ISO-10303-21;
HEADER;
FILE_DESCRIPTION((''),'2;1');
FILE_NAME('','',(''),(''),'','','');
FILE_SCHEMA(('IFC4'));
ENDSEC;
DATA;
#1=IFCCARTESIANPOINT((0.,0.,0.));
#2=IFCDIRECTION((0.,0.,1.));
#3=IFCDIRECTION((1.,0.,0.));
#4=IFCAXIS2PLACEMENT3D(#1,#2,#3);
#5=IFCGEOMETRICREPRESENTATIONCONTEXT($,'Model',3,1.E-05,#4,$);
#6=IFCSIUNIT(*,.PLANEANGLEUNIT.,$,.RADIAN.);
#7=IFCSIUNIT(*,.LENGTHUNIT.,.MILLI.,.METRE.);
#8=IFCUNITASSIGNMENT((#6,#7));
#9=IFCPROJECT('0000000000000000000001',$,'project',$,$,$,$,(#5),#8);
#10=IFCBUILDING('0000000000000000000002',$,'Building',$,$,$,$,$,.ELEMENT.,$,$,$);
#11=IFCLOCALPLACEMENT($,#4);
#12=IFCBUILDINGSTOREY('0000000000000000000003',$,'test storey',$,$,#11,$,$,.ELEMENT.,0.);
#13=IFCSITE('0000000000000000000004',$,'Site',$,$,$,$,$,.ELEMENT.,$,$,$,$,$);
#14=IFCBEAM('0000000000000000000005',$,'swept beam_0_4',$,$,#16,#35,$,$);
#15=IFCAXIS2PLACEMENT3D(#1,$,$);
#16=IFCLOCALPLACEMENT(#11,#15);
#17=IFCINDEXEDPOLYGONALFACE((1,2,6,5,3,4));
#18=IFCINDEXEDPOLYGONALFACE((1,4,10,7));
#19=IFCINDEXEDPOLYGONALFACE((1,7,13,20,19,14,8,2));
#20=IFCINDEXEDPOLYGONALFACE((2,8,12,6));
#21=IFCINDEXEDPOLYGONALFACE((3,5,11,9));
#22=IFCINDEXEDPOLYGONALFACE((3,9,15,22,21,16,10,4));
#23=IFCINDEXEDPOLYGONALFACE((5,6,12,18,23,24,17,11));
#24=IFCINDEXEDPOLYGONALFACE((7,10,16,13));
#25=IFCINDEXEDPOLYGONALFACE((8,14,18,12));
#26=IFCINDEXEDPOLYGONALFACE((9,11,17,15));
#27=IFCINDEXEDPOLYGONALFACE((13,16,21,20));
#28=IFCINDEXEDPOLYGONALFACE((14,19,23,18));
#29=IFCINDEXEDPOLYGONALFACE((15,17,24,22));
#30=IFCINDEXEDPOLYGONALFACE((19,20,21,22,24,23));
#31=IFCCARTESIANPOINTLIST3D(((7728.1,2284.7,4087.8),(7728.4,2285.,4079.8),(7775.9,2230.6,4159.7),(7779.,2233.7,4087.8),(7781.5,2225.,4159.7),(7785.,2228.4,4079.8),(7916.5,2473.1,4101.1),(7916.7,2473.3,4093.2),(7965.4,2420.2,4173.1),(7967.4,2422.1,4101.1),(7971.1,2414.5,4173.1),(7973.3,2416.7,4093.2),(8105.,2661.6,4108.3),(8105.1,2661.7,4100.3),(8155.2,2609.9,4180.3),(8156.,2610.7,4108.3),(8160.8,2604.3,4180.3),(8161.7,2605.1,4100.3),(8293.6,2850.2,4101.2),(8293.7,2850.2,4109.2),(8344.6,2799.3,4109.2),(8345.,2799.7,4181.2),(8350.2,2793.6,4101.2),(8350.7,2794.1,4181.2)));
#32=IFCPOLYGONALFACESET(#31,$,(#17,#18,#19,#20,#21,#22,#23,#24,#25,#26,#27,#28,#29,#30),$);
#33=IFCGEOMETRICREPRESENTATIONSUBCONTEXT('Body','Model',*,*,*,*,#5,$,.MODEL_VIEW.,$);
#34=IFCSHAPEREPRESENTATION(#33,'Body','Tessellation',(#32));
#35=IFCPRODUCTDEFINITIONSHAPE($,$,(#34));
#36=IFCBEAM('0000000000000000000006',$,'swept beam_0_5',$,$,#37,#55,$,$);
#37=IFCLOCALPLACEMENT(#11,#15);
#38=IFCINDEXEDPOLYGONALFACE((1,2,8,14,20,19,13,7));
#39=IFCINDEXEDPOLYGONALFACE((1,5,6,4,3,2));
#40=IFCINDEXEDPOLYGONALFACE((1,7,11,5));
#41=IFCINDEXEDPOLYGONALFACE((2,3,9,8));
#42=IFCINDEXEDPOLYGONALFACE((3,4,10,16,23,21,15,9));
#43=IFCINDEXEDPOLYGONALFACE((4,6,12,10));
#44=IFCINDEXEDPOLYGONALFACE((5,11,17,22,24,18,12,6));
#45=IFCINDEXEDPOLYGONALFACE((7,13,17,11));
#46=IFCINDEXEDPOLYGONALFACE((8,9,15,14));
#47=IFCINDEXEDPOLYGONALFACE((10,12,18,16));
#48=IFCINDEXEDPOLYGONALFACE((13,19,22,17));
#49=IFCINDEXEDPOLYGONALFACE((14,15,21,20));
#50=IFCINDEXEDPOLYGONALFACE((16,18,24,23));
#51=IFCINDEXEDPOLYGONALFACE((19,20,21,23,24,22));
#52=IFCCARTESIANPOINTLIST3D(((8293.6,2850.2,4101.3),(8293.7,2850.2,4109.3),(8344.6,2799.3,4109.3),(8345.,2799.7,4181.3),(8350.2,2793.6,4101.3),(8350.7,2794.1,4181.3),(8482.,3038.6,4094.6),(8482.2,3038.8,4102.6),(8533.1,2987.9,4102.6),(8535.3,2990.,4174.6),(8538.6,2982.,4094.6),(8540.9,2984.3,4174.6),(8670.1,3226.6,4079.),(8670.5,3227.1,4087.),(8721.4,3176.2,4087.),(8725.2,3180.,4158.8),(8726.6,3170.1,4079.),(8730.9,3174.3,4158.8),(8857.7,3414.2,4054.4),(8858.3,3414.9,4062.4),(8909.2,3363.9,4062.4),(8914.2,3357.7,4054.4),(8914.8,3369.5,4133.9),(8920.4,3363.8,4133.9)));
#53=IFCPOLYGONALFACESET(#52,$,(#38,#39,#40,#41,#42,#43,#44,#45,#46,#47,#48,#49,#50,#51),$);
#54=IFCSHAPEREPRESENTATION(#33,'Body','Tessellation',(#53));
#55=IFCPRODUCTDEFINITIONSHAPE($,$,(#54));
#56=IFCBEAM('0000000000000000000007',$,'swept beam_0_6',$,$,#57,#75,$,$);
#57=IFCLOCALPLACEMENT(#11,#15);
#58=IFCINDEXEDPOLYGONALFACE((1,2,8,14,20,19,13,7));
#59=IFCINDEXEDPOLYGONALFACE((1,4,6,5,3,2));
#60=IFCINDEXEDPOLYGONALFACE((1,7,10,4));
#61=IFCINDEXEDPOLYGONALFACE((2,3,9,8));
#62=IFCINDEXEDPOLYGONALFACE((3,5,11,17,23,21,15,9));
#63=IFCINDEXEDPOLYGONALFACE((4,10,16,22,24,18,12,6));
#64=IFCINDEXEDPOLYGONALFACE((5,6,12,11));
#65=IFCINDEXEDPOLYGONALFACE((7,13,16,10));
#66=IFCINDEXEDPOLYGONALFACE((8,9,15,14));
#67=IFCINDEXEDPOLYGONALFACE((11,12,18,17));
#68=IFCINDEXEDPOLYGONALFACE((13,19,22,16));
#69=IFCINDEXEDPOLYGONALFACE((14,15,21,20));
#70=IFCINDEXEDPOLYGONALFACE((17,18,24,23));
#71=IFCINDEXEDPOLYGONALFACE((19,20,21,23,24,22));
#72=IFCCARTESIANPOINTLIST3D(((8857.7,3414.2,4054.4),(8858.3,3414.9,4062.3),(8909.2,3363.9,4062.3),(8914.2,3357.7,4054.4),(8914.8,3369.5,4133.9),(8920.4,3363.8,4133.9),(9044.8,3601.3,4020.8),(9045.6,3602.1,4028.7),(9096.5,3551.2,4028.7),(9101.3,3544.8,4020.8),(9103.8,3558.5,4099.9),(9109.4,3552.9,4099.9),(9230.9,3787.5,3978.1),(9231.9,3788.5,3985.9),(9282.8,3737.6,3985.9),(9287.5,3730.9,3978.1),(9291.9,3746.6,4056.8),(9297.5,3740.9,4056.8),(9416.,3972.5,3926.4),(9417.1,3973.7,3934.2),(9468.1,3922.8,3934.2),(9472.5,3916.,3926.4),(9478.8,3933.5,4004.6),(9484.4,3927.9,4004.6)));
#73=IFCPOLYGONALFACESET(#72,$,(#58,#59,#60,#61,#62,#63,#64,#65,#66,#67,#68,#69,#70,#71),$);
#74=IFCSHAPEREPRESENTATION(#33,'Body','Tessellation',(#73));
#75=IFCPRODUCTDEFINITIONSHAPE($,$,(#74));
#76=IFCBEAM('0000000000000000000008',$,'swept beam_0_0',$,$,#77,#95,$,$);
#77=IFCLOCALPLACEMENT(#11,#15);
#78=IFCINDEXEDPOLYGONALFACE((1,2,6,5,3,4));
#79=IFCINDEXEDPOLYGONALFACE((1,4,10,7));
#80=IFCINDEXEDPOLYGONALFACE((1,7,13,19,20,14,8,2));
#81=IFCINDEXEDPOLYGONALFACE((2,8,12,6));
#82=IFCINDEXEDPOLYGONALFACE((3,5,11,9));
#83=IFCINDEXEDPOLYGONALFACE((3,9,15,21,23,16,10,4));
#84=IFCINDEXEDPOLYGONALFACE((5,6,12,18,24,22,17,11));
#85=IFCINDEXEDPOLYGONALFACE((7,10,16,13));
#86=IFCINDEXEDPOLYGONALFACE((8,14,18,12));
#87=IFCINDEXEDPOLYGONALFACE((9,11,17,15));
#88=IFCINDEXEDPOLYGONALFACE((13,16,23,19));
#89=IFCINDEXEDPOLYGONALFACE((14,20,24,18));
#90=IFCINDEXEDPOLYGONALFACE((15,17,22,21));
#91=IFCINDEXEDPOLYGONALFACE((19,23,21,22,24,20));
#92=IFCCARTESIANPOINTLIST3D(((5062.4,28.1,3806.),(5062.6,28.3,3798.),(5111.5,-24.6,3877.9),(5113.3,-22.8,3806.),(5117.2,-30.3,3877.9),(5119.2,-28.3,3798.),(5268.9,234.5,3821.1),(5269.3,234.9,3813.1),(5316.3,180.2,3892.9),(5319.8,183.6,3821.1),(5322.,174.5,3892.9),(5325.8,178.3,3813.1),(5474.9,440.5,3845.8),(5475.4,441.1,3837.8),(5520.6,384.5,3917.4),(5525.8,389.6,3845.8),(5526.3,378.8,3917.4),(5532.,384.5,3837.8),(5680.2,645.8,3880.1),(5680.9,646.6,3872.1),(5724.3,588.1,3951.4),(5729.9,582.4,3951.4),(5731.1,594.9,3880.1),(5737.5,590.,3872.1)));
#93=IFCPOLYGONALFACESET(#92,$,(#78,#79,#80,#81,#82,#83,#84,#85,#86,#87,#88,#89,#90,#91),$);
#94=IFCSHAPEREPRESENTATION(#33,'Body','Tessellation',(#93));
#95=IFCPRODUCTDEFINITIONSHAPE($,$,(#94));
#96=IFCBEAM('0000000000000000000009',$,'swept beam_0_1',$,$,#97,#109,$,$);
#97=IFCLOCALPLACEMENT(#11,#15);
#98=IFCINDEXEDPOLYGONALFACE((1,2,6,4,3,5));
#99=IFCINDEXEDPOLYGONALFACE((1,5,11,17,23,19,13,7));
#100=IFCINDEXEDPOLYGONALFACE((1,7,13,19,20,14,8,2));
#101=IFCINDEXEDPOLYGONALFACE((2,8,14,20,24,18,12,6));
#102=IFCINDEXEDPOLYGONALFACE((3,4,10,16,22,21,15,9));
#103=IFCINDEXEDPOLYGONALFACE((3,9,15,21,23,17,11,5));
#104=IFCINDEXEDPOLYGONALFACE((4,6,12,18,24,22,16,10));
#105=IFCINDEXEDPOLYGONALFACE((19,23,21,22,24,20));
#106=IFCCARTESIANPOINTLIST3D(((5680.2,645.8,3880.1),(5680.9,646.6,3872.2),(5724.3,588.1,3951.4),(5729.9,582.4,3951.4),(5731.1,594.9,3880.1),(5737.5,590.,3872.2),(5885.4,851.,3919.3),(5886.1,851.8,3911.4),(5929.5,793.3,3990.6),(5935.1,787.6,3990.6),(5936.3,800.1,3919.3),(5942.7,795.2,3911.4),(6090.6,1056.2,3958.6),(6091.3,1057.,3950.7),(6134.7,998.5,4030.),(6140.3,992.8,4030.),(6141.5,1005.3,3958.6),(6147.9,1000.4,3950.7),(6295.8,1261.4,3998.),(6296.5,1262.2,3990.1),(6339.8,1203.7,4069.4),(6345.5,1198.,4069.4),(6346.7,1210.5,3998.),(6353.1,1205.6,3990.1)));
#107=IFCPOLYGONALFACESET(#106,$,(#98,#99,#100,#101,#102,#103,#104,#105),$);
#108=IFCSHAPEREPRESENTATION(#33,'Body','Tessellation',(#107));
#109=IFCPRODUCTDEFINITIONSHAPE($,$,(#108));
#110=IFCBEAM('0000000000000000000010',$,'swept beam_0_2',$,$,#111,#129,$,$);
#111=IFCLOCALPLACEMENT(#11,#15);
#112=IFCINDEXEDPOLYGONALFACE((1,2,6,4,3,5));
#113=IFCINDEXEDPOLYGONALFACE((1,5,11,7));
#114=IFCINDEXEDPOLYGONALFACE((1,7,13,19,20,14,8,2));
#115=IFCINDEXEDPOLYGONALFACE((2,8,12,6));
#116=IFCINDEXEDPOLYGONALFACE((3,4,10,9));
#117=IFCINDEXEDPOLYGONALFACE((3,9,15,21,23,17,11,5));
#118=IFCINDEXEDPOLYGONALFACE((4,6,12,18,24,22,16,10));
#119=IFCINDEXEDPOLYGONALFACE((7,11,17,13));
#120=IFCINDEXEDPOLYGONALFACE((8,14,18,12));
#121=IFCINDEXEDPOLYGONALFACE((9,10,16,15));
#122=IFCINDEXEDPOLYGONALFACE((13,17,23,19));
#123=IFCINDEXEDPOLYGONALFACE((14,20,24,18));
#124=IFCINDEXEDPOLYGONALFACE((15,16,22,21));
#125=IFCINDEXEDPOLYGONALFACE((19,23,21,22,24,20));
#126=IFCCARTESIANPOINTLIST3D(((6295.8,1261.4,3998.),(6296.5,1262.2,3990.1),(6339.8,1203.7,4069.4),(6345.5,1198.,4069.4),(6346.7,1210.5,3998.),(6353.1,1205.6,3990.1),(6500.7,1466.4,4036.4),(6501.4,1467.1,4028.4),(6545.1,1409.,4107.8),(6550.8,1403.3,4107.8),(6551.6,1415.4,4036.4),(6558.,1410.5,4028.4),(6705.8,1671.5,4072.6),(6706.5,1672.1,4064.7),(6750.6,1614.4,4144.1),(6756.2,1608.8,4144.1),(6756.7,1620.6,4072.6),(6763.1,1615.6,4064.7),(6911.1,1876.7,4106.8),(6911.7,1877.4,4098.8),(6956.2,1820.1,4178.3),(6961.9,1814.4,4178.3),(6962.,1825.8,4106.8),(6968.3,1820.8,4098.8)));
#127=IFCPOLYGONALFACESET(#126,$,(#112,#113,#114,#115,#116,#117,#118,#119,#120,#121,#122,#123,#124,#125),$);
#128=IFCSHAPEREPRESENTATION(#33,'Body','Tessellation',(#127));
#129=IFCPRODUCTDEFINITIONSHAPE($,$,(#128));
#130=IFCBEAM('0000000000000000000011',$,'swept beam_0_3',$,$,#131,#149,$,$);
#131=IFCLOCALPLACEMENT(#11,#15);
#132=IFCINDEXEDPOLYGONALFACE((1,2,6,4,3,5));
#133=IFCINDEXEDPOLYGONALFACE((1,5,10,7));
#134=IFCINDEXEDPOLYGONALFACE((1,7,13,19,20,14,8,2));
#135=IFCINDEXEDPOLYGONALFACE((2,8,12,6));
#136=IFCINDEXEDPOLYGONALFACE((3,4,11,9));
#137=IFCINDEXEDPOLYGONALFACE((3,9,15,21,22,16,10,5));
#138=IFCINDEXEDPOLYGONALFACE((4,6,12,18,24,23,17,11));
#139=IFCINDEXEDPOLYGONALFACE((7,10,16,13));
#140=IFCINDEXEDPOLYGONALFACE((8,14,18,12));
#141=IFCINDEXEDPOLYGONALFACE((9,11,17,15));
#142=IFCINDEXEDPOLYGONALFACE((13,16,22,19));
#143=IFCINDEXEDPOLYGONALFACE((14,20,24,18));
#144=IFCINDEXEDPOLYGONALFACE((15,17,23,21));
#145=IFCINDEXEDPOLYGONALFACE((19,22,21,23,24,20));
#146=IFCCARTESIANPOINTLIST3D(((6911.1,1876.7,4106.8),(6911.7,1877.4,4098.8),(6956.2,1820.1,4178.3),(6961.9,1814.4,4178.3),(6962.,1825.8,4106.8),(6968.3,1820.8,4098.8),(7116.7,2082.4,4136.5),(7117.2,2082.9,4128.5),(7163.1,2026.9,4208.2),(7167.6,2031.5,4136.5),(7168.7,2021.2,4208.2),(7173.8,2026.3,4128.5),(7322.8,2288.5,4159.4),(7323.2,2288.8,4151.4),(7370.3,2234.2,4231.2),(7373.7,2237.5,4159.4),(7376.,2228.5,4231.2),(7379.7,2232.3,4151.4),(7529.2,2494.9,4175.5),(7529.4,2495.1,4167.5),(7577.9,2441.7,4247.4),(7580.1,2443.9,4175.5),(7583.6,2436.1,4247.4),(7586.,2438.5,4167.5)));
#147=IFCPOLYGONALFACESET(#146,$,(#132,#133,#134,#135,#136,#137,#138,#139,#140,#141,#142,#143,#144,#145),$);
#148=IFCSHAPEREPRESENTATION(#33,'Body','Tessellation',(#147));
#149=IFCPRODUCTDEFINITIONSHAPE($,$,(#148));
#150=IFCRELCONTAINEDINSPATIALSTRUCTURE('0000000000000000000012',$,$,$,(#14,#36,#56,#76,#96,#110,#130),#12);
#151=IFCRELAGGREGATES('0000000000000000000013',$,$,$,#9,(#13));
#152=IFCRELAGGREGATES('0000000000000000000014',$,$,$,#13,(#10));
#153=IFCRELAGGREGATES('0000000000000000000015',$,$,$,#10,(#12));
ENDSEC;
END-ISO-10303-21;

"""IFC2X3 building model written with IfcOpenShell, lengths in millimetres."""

from ifc_helpers import new_model, entity, si_unit, origin_with_axes, place, context, subcontext, project, spatial, element, save


model = new_model("IFC2X3")

# Units and contexts
model_context = context("Model", 3, precision=1e-05, world=origin_with_axes())
body_context = subcontext(model_context, "Body", "Model", "MODEL_VIEW")
ifc_project = project(units=[si_unit("PLANEANGLEUNIT", "RADIAN"), si_unit("LENGTHUNIT", "METRE", prefix="MILLI")], contexts=[model_context])

# Site, building, storey
site = spatial("IfcSite", under=ifc_project, Name="Site", CompositionType="ELEMENT")
building = spatial("IfcBuilding", under=site, Name="Building", CompositionType="ELEMENT")
storey_placement = place(None, origin_with_axes())
storey = spatial("IfcBuildingStorey", under=building, at=storey_placement, Name="test storey", CompositionType="ELEMENT", Elevation=0.0)

# Beams
beam_1_placement = place(storey_placement, origin_with_axes())
element("IfcBeam", 1, at=beam_1_placement, inside=storey, Name="swept beam_0_4", context=body_context, shape_type="SweptSolid", body=[
    entity("IfcRevolvedAreaSolid", entity("IfcArbitraryClosedProfileDef", "AREA", None, entity("IfcPolyline", [entity("IfcCartesianPoint", [80.0, -40.0]), entity("IfcCartesianPoint", [80.0, -32.0]), entity("IfcCartesianPoint", [8.0, -32.0]), entity("IfcCartesianPoint", [8.0, 40.0]), entity("IfcCartesianPoint", [0.0, 40.0]), entity("IfcCartesianPoint", [0.0, -40.0]), entity("IfcCartesianPoint", [80.0, -40.0])])), entity("IfcAxis2Placement3D", entity("IfcCartesianPoint", [7756.7, 2256.7, 4079.8]), entity("IfcDirection", [-0.7058, -0.7058, -0.0616]), entity("IfcDirection", [-0.0436, -0.0436, 0.9981])), entity("IfcAxis1Placement", entity("IfcCartesianPoint", [-11472.8, 0.0, 0.0]), entity("IfcDirection", [0.0, 1.0, 0.0])), 0.069708),
])
beam_2_placement = place(storey_placement, origin_with_axes())
element("IfcBeam", 2, at=beam_2_placement, inside=storey, Name="swept beam_0_5", context=body_context, shape_type="SweptSolid", body=[
    entity("IfcRevolvedAreaSolid", entity("IfcArbitraryClosedProfileDef", "AREA", None, entity("IfcPolyline", [entity("IfcCartesianPoint", [80.0, -40.0]), entity("IfcCartesianPoint", [80.0, -32.0]), entity("IfcCartesianPoint", [8.0, -32.0]), entity("IfcCartesianPoint", [8.0, 40.0]), entity("IfcCartesianPoint", [0.0, 40.0]), entity("IfcCartesianPoint", [0.0, -40.0]), entity("IfcCartesianPoint", [80.0, -40.0])])), entity("IfcAxis2Placement3D", entity("IfcCartesianPoint", [8321.9, 2821.9, 4101.3]), entity("IfcDirection", [-0.7071, -0.7071, 0.008]), entity("IfcDirection", [0.0057, 0.0057, 1.0])), entity("IfcAxis1Placement", entity("IfcCartesianPoint", [-7891.4, 0.0, 0.0]), entity("IfcDirection", [0.0, 1.0, 0.0])), 0.101299),
])
beam_3_placement = place(storey_placement, origin_with_axes())
element("IfcBeam", 3, at=beam_3_placement, inside=storey, Name="swept beam_0_6", context=body_context, shape_type="SweptSolid", body=[
    entity("IfcRevolvedAreaSolid", entity("IfcArbitraryClosedProfileDef", "AREA", None, entity("IfcPolyline", [entity("IfcCartesianPoint", [80.0, -40.0]), entity("IfcCartesianPoint", [80.0, -32.0]), entity("IfcCartesianPoint", [8.0, -32.0]), entity("IfcCartesianPoint", [8.0, 40.0]), entity("IfcCartesianPoint", [0.0, 40.0]), entity("IfcCartesianPoint", [0.0, -40.0]), entity("IfcCartesianPoint", [80.0, -40.0])])), entity("IfcAxis2Placement3D", entity("IfcCartesianPoint", [8886.0, 3386.0, 4054.4]), entity("IfcDirection", [-0.7029, -0.7029, 0.1091]), entity("IfcDirection", [0.0772, 0.0772, 0.994])), entity("IfcAxis1Placement", entity("IfcCartesianPoint", [-7780.5, 0.0, 0.0]), entity("IfcDirection", [0.0, 1.0, 0.0])), 0.102847),
])
beam_4_placement = place(storey_placement, origin_with_axes())
element("IfcBeam", 4, at=beam_4_placement, inside=storey, Name="swept beam_0_0", context=body_context, shape_type="SweptSolid", body=[
    entity("IfcRevolvedAreaSolid", entity("IfcArbitraryClosedProfileDef", "AREA", None, entity("IfcPolyline", [entity("IfcCartesianPoint", [-80.0, 40.0]), entity("IfcCartesianPoint", [-80.0, 32.0]), entity("IfcCartesianPoint", [-8.0, 32.0]), entity("IfcCartesianPoint", [-8.0, -40.0]), entity("IfcCartesianPoint", [0.0, -40.0]), entity("IfcCartesianPoint", [0.0, 40.0]), entity("IfcCartesianPoint", [-80.0, 40.0])])), entity("IfcAxis2Placement3D", entity("IfcCartesianPoint", [5090.9, 0.0, 3798.0]), entity("IfcDirection", [-0.7067, -0.7067, -0.0352]), entity("IfcDirection", [0.0249, 0.0249, -0.9994])), entity("IfcAxis1Placement", entity("IfcCartesianPoint", [-8878.9, 0.0, 0.0]), entity("IfcDirection", [0.0, 1.0, 0.0])), 0.098873),
])
beam_5_placement = place(storey_placement, origin_with_axes())
element("IfcBeam", 5, at=beam_5_placement, inside=storey, Name="swept beam_0_1", context=body_context, shape_type="SweptSolid", body=[
    entity("IfcRevolvedAreaSolid", entity("IfcArbitraryClosedProfileDef", "AREA", None, entity("IfcPolyline", [entity("IfcCartesianPoint", [-80.0, 40.0]), entity("IfcCartesianPoint", [-80.0, 32.0]), entity("IfcCartesianPoint", [-8.0, 32.0]), entity("IfcCartesianPoint", [-8.0, -40.0]), entity("IfcCartesianPoint", [0.0, -40.0]), entity("IfcCartesianPoint", [0.0, 40.0]), entity("IfcCartesianPoint", [-80.0, 40.0])])), entity("IfcAxis2Placement3D", entity("IfcCartesianPoint", [5709.2, 618.3, 3872.2]), entity("IfcDirection", [-0.7008, -0.7008, -0.1337]), entity("IfcDirection", [0.0945, 0.0945, -0.991])), entity("IfcAxis1Placement", entity("IfcCartesianPoint", [-781653.4, 0.0, 0.0]), entity("IfcDirection", [0.0, 1.0, 0.0])), 0.001124),
])
beam_6_placement = place(storey_placement, origin_with_axes())
element("IfcBeam", 6, at=beam_6_placement, inside=storey, Name="swept beam_0_2", context=body_context, shape_type="SweptSolid", body=[
    entity("IfcRevolvedAreaSolid", entity("IfcArbitraryClosedProfileDef", "AREA", None, entity("IfcPolyline", [entity("IfcCartesianPoint", [80.0, -40.0]), entity("IfcCartesianPoint", [80.0, -32.0]), entity("IfcCartesianPoint", [8.0, -32.0]), entity("IfcCartesianPoint", [8.0, 40.0]), entity("IfcCartesianPoint", [0.0, 40.0]), entity("IfcCartesianPoint", [0.0, -40.0]), entity("IfcCartesianPoint", [80.0, -40.0])])), entity("IfcAxis2Placement3D", entity("IfcCartesianPoint", [6324.8, 1233.9, 3990.1]), entity("IfcDirection", [-0.7007, -0.7007, -0.1348]), entity("IfcDirection", [-0.0953, -0.0953, 0.9909])), entity("IfcAxis1Placement", entity("IfcCartesianPoint", [-40340.5, 0.0, 0.0]), entity("IfcDirection", [0.0, 1.0, 0.0])), 0.021734),
])
beam_7_placement = place(storey_placement, origin_with_axes())
element("IfcBeam", 7, at=beam_7_placement, inside=storey, Name="swept beam_0_3", context=body_context, shape_type="SweptSolid", body=[
    entity("IfcRevolvedAreaSolid", entity("IfcArbitraryClosedProfileDef", "AREA", None, entity("IfcPolyline", [entity("IfcCartesianPoint", [80.0, -40.0]), entity("IfcCartesianPoint", [80.0, -32.0]), entity("IfcCartesianPoint", [8.0, -32.0]), entity("IfcCartesianPoint", [8.0, 40.0]), entity("IfcCartesianPoint", [0.0, 40.0]), entity("IfcCartesianPoint", [0.0, -40.0]), entity("IfcCartesianPoint", [80.0, -40.0])])), entity("IfcAxis2Placement3D", entity("IfcCartesianPoint", [6940.0, 1849.1, 4098.8]), entity("IfcDirection", [-0.7026, -0.7026, -0.1132]), entity("IfcDirection", [-0.0801, -0.0801, 0.9936])), entity("IfcAxis1Placement", entity("IfcCartesianPoint", [-12505.9, 0.0, 0.0]), entity("IfcDirection", [0.0, 1.0, 0.0])), 0.070083),
])

save(model, "model.ifc")
